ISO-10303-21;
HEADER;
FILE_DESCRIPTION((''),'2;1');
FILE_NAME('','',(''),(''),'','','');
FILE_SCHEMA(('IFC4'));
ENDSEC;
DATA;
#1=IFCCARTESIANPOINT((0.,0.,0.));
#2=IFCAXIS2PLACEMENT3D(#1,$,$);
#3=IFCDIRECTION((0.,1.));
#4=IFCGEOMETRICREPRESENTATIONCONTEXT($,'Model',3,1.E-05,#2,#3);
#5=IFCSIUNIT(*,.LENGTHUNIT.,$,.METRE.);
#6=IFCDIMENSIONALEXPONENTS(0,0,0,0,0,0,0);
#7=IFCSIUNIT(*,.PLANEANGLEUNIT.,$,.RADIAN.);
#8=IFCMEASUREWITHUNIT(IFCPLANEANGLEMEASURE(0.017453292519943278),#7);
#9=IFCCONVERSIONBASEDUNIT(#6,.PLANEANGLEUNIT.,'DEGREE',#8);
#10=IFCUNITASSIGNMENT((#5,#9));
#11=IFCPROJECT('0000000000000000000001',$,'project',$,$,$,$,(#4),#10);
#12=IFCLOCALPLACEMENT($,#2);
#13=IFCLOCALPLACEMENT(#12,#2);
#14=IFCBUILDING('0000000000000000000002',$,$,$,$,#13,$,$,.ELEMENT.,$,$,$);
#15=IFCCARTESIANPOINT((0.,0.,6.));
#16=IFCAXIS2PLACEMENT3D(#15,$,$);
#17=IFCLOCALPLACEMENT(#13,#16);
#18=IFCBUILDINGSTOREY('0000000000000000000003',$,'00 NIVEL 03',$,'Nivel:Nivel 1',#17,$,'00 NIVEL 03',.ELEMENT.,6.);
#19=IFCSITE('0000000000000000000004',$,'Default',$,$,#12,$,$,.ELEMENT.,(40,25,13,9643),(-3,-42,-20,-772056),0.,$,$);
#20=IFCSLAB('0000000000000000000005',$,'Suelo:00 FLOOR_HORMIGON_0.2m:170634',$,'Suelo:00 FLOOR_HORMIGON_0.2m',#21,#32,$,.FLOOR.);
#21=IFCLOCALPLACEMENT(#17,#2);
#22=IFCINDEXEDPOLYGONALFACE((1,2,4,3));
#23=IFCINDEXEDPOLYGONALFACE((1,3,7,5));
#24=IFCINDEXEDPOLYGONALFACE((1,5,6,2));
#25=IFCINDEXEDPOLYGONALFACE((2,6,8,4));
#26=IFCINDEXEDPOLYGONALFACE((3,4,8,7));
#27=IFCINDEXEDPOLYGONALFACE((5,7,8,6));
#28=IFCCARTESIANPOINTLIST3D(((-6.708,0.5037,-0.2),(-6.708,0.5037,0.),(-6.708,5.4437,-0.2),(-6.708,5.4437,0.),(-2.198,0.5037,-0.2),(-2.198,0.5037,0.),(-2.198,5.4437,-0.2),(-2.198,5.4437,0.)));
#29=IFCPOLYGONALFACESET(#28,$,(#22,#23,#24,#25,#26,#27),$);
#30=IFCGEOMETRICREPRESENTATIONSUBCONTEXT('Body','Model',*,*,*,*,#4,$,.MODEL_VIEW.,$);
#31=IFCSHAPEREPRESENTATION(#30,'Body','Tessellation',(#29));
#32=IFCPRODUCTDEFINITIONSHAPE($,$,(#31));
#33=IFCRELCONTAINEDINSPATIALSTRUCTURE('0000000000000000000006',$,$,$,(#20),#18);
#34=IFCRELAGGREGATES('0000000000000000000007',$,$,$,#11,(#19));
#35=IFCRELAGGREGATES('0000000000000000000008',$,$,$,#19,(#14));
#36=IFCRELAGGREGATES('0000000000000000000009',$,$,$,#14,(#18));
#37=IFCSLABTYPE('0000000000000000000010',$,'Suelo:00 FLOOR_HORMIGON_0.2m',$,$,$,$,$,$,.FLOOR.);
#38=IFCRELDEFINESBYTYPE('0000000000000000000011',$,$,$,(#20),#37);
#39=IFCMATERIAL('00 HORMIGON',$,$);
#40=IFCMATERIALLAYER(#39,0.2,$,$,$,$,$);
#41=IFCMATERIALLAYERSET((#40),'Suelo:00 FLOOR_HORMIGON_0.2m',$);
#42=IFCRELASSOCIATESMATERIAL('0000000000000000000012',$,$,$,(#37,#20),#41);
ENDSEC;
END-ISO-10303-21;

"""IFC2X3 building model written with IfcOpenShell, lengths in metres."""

from ifc_helpers import new_model, entity, si_unit, converted_unit, direction, frame, frame_2d, origin, place, context, subcontext, project, spatial, rectangle, extrude, material, layer, layer_set, layer_usage, type_object, element, save


model = new_model("IFC2X3")

# Units and contexts
model_context = context("Model", 3, precision=1e-05, world=origin(), true_north=direction((0.0, 1.0)))
body_context = subcontext(model_context, "Body", "Model", "MODEL_VIEW")
ifc_project = project(units=[si_unit("LENGTHUNIT", "METRE"), converted_unit("PLANEANGLEUNIT", "DEGREE", entity("IfcPlaneAngleMeasure", 0.017453292519943278), si_unit("PLANEANGLEUNIT", "RADIAN"), dimensions=[0, 0, 0, 0, 0, 0, 0])], contexts=[model_context])

# Site, building, storey
site_placement = place(None, origin())
site = spatial("IfcSite", under=ifc_project, at=site_placement, Name="Default", CompositionType="ELEMENT", RefLatitude=(40, 25, 13, 9643), RefLongitude=(-3, -42, -20, -772056), RefElevation=0.0)
building_placement = place(site_placement, origin())
building = spatial("IfcBuilding", under=site, at=building_placement, CompositionType="ELEMENT")
storey_placement = place(building_placement, frame((0.0, 0.0, 6.0)))
storey = spatial("IfcBuildingStorey", under=building, at=storey_placement, Name="00 NIVEL 03", ObjectType="Nivel:Nivel 1", LongName="00 NIVEL 03", CompositionType="ELEMENT", Elevation=6.0)

# Slab
ifc_material = material(Name="00 HORMIGON")
ifc_layer = layer(ifc_material, 0.2)
ifc_layer_set = layer_set([ifc_layer], Name="Suelo:00 FLOOR_HORMIGON_0.2m")
ifc_layer_usage = layer_usage(ifc_layer_set, "AXIS3", "POSITIVE", 0.0)
slab_type = type_object("IfcSlabType", Name="Suelo:00 FLOOR_HORMIGON_0.2m", PredefinedType="FLOOR", material=ifc_layer_set)
slab_placement = place(storey_placement, origin())
element("IfcSlab", 1, at=slab_placement, inside=storey, type_object=slab_type, material=ifc_layer_usage, Name="Suelo:00 FLOOR_HORMIGON_0.2m:170634", ObjectType="Suelo:00 FLOOR_HORMIGON_0.2m", PredefinedType="FLOOR", context=body_context, shape_type="SweptSolid", body=[
    extrude(rectangle(XDim=4.94, YDim=4.51, at=frame_2d((0.0, 0.0), x_axis=(1.0, 0.0))), frame((-4.453, 2.9737, 0.0), z_axis=(0.0, 0.0, -1.0), x_axis=(0.0, 1.0, 0.0)), (0.0, 0.0, 1.0), 0.2),
])

save(model, "model.ifc")
